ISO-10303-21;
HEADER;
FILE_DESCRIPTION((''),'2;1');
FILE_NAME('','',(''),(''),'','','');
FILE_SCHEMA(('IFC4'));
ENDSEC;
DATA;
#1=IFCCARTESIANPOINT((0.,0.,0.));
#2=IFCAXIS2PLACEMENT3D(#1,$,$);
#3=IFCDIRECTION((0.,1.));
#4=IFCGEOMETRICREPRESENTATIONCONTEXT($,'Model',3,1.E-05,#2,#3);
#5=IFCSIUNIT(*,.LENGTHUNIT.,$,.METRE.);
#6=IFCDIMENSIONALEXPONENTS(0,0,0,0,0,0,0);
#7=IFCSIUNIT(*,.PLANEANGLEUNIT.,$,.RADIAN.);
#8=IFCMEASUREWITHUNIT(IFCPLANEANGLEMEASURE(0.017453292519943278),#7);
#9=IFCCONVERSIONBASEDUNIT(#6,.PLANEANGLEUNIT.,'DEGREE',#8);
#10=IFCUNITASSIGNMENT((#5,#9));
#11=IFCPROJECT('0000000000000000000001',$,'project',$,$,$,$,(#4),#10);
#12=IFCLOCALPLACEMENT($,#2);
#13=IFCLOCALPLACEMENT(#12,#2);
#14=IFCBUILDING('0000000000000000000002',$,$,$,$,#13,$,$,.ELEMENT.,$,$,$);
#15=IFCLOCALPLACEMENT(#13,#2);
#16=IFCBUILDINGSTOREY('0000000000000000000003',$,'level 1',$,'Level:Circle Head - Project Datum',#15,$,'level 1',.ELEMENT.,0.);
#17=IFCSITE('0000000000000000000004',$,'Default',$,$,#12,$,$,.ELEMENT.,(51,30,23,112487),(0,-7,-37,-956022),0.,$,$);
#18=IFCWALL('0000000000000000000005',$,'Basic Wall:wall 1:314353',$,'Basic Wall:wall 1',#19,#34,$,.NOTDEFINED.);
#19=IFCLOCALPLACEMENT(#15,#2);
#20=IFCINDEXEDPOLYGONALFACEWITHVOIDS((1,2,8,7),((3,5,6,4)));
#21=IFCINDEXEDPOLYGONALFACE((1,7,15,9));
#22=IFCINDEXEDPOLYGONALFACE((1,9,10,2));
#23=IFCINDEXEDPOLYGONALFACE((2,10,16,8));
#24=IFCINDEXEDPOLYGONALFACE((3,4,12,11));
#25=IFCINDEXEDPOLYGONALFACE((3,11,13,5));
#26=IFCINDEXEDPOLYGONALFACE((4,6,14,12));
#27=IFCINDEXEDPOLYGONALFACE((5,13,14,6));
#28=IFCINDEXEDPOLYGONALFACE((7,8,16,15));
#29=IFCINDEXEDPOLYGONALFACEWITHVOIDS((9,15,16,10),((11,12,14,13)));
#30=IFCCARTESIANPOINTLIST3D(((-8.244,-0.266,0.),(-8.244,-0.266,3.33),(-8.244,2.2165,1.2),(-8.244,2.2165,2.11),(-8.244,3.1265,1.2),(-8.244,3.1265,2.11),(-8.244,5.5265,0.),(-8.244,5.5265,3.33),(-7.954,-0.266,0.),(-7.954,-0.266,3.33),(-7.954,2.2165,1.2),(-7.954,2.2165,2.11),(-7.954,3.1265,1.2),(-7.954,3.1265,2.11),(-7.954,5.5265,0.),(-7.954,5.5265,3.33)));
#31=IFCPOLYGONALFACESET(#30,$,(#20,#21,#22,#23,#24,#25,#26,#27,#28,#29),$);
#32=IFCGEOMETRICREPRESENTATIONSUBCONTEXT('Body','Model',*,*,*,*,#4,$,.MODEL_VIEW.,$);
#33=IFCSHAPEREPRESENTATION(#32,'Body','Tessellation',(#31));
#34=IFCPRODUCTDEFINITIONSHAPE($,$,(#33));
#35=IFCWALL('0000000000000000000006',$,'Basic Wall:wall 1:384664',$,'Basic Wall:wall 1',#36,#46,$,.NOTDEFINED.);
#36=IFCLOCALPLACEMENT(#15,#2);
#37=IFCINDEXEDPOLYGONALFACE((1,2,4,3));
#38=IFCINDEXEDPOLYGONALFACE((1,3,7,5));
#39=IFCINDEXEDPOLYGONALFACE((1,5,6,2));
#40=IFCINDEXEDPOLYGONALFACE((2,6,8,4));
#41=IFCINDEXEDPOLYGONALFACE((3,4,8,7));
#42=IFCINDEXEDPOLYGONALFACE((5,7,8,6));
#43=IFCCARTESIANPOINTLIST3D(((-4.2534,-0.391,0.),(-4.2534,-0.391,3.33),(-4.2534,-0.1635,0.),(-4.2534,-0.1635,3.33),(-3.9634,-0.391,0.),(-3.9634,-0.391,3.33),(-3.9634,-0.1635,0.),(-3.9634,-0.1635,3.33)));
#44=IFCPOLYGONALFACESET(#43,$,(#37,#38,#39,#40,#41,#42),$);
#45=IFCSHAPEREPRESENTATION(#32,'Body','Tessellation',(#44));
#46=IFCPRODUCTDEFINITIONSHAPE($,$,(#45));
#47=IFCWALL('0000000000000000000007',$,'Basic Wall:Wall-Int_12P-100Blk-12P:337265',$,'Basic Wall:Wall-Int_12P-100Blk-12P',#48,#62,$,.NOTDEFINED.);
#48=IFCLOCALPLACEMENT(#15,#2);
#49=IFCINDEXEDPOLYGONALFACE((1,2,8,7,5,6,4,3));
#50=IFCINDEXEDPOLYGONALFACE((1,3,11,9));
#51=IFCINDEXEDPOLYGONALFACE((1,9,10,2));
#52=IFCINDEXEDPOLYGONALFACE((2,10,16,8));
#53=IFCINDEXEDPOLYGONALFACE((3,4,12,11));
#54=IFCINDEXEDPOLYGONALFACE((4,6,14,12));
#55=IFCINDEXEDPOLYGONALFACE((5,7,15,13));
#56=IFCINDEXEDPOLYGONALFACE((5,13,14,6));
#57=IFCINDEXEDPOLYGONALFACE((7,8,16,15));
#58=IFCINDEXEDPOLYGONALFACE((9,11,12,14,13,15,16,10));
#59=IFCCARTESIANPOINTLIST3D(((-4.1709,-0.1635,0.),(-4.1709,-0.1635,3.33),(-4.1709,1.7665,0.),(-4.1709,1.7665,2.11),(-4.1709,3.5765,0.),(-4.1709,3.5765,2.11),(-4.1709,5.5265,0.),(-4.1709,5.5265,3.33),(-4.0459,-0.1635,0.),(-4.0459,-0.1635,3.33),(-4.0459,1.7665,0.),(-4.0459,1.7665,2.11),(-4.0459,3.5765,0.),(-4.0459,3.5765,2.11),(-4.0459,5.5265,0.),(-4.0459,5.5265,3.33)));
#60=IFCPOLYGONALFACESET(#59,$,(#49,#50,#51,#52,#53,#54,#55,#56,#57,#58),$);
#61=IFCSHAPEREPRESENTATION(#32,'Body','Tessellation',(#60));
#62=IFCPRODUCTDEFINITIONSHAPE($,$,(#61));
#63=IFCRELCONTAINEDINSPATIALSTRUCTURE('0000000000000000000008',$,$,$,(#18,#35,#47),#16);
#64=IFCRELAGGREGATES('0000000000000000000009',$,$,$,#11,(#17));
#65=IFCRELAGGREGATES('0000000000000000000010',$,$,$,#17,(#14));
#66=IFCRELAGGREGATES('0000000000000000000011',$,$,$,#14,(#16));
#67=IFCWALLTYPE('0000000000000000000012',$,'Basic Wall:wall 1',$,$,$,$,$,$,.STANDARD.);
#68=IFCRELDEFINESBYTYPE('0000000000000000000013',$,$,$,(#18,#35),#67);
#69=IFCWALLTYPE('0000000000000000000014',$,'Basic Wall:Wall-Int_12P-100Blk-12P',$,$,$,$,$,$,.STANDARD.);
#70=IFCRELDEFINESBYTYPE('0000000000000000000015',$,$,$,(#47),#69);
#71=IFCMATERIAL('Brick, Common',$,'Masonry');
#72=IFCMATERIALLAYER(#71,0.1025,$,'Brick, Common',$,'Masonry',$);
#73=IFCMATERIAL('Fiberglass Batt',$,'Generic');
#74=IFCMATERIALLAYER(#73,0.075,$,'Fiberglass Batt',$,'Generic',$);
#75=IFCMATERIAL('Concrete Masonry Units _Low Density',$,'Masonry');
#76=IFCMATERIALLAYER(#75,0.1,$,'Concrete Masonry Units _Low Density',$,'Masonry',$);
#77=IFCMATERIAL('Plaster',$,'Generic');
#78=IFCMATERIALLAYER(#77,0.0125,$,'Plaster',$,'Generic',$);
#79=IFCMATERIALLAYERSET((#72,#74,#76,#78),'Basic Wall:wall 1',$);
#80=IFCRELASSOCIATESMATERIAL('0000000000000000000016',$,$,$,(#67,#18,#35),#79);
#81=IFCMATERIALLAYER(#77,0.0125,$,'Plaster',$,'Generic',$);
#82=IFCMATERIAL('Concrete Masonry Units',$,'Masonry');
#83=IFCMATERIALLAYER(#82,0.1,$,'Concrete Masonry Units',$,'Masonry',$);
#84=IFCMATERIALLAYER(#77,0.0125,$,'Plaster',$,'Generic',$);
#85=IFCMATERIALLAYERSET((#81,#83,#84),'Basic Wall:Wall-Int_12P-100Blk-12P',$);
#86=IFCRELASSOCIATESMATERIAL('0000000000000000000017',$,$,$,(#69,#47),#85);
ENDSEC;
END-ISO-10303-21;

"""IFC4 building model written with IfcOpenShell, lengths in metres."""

from ifc_helpers import new_model, entity, si_unit, converted_unit, direction, frame, frame_2d, origin, place, context, subcontext, project, spatial, polyline, rectangle, extrude, clip, bounded_halfspace, material, layer, layer_set, layer_usage, type_object, element, save


model = new_model("IFC4")

# Units and contexts
model_context = context("Model", 3, precision=1e-05, world=origin(), true_north=direction((0.0, 1.0)))
body_context = subcontext(model_context, "Body", "Model", "MODEL_VIEW")
ifc_project = project(units=[si_unit("LENGTHUNIT", "METRE"), converted_unit("PLANEANGLEUNIT", "DEGREE", entity("IfcPlaneAngleMeasure", 0.017453292519943278), si_unit("PLANEANGLEUNIT", "RADIAN"), dimensions=[0, 0, 0, 0, 0, 0, 0])], contexts=[model_context])

# Site, building, storey
site_placement = place(None, origin())
site = spatial("IfcSite", under=ifc_project, at=site_placement, Name="Default", CompositionType="ELEMENT", RefLatitude=(51, 30, 23, 112487), RefLongitude=(0, -7, -37, -956022), RefElevation=0.0)
building_placement = place(site_placement, origin())
building = spatial("IfcBuilding", under=site, at=building_placement, CompositionType="ELEMENT")
storey_placement = place(building_placement, origin())
storey = spatial("IfcBuildingStorey", under=building, at=storey_placement, Name="level 1", ObjectType="Level:Circle Head - Project Datum", LongName="level 1", CompositionType="ELEMENT", Elevation=0.0)

# Shared definitions
ifc_material_1 = material(Name="Brick, Common", Category="Masonry")
ifc_layer_1 = layer(ifc_material_1, 0.1025, Name="Brick, Common", Category="Masonry")
ifc_material_2 = material(Name="Fiberglass Batt", Category="Generic")
ifc_layer_2 = layer(ifc_material_2, 0.075, Name="Fiberglass Batt", Category="Generic")
ifc_material_3 = material(Name="Concrete Masonry Units _Low Density", Category="Masonry")
ifc_layer_3 = layer(ifc_material_3, 0.1, Name="Concrete Masonry Units _Low Density", Category="Masonry")
ifc_material_4 = material(Name="Plaster", Category="Generic")
ifc_layer_4 = layer(ifc_material_4, 0.0125, Name="Plaster", Category="Generic")
ifc_layer_set_1 = layer_set([ifc_layer_1, ifc_layer_2, ifc_layer_3, ifc_layer_4], Name="Basic Wall:wall 1")
wall_type_1 = type_object("IfcWallType", Name="Basic Wall:wall 1", PredefinedType="STANDARD", material=ifc_layer_set_1)

# Wall, opening
ifc_layer_usage_1 = layer_usage(ifc_layer_set_1, "AXIS2", "NEGATIVE", 0.145)
wall_1_placement = place(storey_placement, frame((-8.099, -0.266, 0.0), z_axis=(0.0, 0.0, 1.0), x_axis=(0.0, 1.0, 0.0)))
wall_1 = element("IfcWall", 1, at=wall_1_placement, inside=storey, type_object=wall_type_1, material=ifc_layer_usage_1, Name="Basic Wall:wall 1:314353", ObjectType="Basic Wall:wall 1", PredefinedType="NOTDEFINED", context=body_context, shape_type="Clipping", body=[
    clip(extrude(rectangle(XDim=5.7925, YDim=0.29, at=frame_2d((2.8963, 0.0), x_axis=(-1.0, 0.0))), origin(), (0.0, 0.0, 1.0), 3.33), bounded_halfspace(frame((0.0, -0.145, 3.33), z_axis=(0.0, 0.0, -1.0), x_axis=(1.0, 0.0, 0.0)), True, frame((0.0, -0.145, 3.33)), polyline([(0.0, 0.0), (5.7925, 0.0), (5.7925, 0.29), (0.0, 0.29), (0.0, 0.0)]))),
])
opening_1_placement = place(wall_1_placement, frame((2.4825, -0.145, 1.2)))
element("IfcOpeningElement", 2, at=opening_1_placement, cuts=wall_1, PredefinedType="OPENING", context=body_context, shape_type="SweptSolid", body=[
    extrude(rectangle(XDim=0.91, YDim=0.91, at=frame_2d((0.455, 0.455), x_axis=(-1.0, 0.0))), frame((0.0, 0.0, 0.0), z_axis=(0.0, 1.0, 0.0), x_axis=(0.0, 0.0, 1.0)), (0.0, 0.0, 1.0), 0.29),
])

# Wall
ifc_layer_usage_2 = layer_usage(ifc_layer_set_1, "AXIS2", "NEGATIVE", 0.145)
wall_2_placement = place(storey_placement, frame((-4.1084, -0.1635, 0.0), z_axis=(0.0, 0.0, 1.0), x_axis=(0.0, -1.0, 0.0)))
element("IfcWall", 3, at=wall_2_placement, inside=storey, type_object=wall_type_1, material=ifc_layer_usage_2, Name="Basic Wall:wall 1:384664", ObjectType="Basic Wall:wall 1", PredefinedType="NOTDEFINED", context=body_context, shape_type="Clipping", body=[
    clip(extrude(rectangle(XDim=0.2275, YDim=0.29, at=frame_2d((0.1137, 0.0), x_axis=(-1.0, 0.0))), origin(), (0.0, 0.0, 1.0), 3.33), bounded_halfspace(frame((0.0, -0.145, 3.33), z_axis=(0.0, 0.0, -1.0), x_axis=(-1.0, 0.0, 0.0)), True, frame((0.0, -0.145, 3.33)), polyline([(0.0, 0.0), (0.1025, 0.0), (0.2275, 0.0), (0.2275, 0.29), (0.02, 0.29), (0.0, 0.29), (0.0, 0.2075), (0.0, 0.0825), (0.0, 0.0)]))),
])

# Wall, opening
ifc_layer_5 = layer(ifc_material_4, 0.0125, Name="Plaster", Category="Generic")
ifc_material_5 = material(Name="Concrete Masonry Units", Category="Masonry")
ifc_layer_6 = layer(ifc_material_5, 0.1, Name="Concrete Masonry Units", Category="Masonry")
ifc_layer_7 = layer(ifc_material_4, 0.0125, Name="Plaster", Category="Generic")
ifc_layer_set_2 = layer_set([ifc_layer_5, ifc_layer_6, ifc_layer_7], Name="Basic Wall:Wall-Int_12P-100Blk-12P")
ifc_layer_usage_3 = layer_usage(ifc_layer_set_2, "AXIS2", "NEGATIVE", 0.0625)
wall_type_2 = type_object("IfcWallType", Name="Basic Wall:Wall-Int_12P-100Blk-12P", PredefinedType="STANDARD", material=ifc_layer_set_2)
wall_3_placement = place(storey_placement, frame((-4.1084, 5.5265, 0.0), z_axis=(0.0, 0.0, 1.0), x_axis=(0.0, -1.0, 0.0)))
wall_3 = element("IfcWall", 4, at=wall_3_placement, inside=storey, type_object=wall_type_2, material=ifc_layer_usage_3, Name="Basic Wall:Wall-Int_12P-100Blk-12P:337265", ObjectType="Basic Wall:Wall-Int_12P-100Blk-12P", PredefinedType="NOTDEFINED", context=body_context, shape_type="Clipping", body=[
    clip(extrude(rectangle(XDim=5.69, YDim=0.125, at=frame_2d((2.845, 0.0), x_axis=(1.0, 0.0))), origin(), (0.0, 0.0, 1.0), 3.33), bounded_halfspace(frame((0.0, -0.0625, 3.33), z_axis=(0.0, 0.0, -1.0), x_axis=(-1.0, 0.0, 0.0)), True, frame((0.0, -0.0625, 3.33)), polyline([(0.0, 0.0), (5.69, 0.0), (5.69, 0.125), (0.0, 0.125), (0.0, 0.0)]))),
])
opening_2_placement = place(wall_3_placement, frame((3.76, 0.0625, 0.0)))
element("IfcOpeningElement", 5, at=opening_2_placement, cuts=wall_3, PredefinedType="OPENING", context=body_context, shape_type="SweptSolid", body=[
    extrude(rectangle(XDim=2.11, YDim=1.81, at=frame_2d((1.055, 0.905), x_axis=(-1.0, 0.0))), frame((0.0, 0.0, 0.0), z_axis=(0.0, -1.0, 0.0), x_axis=(0.0, 0.0, 1.0)), (0.0, 0.0, 1.0), 0.125),
])

save(model, "model.ifc")
